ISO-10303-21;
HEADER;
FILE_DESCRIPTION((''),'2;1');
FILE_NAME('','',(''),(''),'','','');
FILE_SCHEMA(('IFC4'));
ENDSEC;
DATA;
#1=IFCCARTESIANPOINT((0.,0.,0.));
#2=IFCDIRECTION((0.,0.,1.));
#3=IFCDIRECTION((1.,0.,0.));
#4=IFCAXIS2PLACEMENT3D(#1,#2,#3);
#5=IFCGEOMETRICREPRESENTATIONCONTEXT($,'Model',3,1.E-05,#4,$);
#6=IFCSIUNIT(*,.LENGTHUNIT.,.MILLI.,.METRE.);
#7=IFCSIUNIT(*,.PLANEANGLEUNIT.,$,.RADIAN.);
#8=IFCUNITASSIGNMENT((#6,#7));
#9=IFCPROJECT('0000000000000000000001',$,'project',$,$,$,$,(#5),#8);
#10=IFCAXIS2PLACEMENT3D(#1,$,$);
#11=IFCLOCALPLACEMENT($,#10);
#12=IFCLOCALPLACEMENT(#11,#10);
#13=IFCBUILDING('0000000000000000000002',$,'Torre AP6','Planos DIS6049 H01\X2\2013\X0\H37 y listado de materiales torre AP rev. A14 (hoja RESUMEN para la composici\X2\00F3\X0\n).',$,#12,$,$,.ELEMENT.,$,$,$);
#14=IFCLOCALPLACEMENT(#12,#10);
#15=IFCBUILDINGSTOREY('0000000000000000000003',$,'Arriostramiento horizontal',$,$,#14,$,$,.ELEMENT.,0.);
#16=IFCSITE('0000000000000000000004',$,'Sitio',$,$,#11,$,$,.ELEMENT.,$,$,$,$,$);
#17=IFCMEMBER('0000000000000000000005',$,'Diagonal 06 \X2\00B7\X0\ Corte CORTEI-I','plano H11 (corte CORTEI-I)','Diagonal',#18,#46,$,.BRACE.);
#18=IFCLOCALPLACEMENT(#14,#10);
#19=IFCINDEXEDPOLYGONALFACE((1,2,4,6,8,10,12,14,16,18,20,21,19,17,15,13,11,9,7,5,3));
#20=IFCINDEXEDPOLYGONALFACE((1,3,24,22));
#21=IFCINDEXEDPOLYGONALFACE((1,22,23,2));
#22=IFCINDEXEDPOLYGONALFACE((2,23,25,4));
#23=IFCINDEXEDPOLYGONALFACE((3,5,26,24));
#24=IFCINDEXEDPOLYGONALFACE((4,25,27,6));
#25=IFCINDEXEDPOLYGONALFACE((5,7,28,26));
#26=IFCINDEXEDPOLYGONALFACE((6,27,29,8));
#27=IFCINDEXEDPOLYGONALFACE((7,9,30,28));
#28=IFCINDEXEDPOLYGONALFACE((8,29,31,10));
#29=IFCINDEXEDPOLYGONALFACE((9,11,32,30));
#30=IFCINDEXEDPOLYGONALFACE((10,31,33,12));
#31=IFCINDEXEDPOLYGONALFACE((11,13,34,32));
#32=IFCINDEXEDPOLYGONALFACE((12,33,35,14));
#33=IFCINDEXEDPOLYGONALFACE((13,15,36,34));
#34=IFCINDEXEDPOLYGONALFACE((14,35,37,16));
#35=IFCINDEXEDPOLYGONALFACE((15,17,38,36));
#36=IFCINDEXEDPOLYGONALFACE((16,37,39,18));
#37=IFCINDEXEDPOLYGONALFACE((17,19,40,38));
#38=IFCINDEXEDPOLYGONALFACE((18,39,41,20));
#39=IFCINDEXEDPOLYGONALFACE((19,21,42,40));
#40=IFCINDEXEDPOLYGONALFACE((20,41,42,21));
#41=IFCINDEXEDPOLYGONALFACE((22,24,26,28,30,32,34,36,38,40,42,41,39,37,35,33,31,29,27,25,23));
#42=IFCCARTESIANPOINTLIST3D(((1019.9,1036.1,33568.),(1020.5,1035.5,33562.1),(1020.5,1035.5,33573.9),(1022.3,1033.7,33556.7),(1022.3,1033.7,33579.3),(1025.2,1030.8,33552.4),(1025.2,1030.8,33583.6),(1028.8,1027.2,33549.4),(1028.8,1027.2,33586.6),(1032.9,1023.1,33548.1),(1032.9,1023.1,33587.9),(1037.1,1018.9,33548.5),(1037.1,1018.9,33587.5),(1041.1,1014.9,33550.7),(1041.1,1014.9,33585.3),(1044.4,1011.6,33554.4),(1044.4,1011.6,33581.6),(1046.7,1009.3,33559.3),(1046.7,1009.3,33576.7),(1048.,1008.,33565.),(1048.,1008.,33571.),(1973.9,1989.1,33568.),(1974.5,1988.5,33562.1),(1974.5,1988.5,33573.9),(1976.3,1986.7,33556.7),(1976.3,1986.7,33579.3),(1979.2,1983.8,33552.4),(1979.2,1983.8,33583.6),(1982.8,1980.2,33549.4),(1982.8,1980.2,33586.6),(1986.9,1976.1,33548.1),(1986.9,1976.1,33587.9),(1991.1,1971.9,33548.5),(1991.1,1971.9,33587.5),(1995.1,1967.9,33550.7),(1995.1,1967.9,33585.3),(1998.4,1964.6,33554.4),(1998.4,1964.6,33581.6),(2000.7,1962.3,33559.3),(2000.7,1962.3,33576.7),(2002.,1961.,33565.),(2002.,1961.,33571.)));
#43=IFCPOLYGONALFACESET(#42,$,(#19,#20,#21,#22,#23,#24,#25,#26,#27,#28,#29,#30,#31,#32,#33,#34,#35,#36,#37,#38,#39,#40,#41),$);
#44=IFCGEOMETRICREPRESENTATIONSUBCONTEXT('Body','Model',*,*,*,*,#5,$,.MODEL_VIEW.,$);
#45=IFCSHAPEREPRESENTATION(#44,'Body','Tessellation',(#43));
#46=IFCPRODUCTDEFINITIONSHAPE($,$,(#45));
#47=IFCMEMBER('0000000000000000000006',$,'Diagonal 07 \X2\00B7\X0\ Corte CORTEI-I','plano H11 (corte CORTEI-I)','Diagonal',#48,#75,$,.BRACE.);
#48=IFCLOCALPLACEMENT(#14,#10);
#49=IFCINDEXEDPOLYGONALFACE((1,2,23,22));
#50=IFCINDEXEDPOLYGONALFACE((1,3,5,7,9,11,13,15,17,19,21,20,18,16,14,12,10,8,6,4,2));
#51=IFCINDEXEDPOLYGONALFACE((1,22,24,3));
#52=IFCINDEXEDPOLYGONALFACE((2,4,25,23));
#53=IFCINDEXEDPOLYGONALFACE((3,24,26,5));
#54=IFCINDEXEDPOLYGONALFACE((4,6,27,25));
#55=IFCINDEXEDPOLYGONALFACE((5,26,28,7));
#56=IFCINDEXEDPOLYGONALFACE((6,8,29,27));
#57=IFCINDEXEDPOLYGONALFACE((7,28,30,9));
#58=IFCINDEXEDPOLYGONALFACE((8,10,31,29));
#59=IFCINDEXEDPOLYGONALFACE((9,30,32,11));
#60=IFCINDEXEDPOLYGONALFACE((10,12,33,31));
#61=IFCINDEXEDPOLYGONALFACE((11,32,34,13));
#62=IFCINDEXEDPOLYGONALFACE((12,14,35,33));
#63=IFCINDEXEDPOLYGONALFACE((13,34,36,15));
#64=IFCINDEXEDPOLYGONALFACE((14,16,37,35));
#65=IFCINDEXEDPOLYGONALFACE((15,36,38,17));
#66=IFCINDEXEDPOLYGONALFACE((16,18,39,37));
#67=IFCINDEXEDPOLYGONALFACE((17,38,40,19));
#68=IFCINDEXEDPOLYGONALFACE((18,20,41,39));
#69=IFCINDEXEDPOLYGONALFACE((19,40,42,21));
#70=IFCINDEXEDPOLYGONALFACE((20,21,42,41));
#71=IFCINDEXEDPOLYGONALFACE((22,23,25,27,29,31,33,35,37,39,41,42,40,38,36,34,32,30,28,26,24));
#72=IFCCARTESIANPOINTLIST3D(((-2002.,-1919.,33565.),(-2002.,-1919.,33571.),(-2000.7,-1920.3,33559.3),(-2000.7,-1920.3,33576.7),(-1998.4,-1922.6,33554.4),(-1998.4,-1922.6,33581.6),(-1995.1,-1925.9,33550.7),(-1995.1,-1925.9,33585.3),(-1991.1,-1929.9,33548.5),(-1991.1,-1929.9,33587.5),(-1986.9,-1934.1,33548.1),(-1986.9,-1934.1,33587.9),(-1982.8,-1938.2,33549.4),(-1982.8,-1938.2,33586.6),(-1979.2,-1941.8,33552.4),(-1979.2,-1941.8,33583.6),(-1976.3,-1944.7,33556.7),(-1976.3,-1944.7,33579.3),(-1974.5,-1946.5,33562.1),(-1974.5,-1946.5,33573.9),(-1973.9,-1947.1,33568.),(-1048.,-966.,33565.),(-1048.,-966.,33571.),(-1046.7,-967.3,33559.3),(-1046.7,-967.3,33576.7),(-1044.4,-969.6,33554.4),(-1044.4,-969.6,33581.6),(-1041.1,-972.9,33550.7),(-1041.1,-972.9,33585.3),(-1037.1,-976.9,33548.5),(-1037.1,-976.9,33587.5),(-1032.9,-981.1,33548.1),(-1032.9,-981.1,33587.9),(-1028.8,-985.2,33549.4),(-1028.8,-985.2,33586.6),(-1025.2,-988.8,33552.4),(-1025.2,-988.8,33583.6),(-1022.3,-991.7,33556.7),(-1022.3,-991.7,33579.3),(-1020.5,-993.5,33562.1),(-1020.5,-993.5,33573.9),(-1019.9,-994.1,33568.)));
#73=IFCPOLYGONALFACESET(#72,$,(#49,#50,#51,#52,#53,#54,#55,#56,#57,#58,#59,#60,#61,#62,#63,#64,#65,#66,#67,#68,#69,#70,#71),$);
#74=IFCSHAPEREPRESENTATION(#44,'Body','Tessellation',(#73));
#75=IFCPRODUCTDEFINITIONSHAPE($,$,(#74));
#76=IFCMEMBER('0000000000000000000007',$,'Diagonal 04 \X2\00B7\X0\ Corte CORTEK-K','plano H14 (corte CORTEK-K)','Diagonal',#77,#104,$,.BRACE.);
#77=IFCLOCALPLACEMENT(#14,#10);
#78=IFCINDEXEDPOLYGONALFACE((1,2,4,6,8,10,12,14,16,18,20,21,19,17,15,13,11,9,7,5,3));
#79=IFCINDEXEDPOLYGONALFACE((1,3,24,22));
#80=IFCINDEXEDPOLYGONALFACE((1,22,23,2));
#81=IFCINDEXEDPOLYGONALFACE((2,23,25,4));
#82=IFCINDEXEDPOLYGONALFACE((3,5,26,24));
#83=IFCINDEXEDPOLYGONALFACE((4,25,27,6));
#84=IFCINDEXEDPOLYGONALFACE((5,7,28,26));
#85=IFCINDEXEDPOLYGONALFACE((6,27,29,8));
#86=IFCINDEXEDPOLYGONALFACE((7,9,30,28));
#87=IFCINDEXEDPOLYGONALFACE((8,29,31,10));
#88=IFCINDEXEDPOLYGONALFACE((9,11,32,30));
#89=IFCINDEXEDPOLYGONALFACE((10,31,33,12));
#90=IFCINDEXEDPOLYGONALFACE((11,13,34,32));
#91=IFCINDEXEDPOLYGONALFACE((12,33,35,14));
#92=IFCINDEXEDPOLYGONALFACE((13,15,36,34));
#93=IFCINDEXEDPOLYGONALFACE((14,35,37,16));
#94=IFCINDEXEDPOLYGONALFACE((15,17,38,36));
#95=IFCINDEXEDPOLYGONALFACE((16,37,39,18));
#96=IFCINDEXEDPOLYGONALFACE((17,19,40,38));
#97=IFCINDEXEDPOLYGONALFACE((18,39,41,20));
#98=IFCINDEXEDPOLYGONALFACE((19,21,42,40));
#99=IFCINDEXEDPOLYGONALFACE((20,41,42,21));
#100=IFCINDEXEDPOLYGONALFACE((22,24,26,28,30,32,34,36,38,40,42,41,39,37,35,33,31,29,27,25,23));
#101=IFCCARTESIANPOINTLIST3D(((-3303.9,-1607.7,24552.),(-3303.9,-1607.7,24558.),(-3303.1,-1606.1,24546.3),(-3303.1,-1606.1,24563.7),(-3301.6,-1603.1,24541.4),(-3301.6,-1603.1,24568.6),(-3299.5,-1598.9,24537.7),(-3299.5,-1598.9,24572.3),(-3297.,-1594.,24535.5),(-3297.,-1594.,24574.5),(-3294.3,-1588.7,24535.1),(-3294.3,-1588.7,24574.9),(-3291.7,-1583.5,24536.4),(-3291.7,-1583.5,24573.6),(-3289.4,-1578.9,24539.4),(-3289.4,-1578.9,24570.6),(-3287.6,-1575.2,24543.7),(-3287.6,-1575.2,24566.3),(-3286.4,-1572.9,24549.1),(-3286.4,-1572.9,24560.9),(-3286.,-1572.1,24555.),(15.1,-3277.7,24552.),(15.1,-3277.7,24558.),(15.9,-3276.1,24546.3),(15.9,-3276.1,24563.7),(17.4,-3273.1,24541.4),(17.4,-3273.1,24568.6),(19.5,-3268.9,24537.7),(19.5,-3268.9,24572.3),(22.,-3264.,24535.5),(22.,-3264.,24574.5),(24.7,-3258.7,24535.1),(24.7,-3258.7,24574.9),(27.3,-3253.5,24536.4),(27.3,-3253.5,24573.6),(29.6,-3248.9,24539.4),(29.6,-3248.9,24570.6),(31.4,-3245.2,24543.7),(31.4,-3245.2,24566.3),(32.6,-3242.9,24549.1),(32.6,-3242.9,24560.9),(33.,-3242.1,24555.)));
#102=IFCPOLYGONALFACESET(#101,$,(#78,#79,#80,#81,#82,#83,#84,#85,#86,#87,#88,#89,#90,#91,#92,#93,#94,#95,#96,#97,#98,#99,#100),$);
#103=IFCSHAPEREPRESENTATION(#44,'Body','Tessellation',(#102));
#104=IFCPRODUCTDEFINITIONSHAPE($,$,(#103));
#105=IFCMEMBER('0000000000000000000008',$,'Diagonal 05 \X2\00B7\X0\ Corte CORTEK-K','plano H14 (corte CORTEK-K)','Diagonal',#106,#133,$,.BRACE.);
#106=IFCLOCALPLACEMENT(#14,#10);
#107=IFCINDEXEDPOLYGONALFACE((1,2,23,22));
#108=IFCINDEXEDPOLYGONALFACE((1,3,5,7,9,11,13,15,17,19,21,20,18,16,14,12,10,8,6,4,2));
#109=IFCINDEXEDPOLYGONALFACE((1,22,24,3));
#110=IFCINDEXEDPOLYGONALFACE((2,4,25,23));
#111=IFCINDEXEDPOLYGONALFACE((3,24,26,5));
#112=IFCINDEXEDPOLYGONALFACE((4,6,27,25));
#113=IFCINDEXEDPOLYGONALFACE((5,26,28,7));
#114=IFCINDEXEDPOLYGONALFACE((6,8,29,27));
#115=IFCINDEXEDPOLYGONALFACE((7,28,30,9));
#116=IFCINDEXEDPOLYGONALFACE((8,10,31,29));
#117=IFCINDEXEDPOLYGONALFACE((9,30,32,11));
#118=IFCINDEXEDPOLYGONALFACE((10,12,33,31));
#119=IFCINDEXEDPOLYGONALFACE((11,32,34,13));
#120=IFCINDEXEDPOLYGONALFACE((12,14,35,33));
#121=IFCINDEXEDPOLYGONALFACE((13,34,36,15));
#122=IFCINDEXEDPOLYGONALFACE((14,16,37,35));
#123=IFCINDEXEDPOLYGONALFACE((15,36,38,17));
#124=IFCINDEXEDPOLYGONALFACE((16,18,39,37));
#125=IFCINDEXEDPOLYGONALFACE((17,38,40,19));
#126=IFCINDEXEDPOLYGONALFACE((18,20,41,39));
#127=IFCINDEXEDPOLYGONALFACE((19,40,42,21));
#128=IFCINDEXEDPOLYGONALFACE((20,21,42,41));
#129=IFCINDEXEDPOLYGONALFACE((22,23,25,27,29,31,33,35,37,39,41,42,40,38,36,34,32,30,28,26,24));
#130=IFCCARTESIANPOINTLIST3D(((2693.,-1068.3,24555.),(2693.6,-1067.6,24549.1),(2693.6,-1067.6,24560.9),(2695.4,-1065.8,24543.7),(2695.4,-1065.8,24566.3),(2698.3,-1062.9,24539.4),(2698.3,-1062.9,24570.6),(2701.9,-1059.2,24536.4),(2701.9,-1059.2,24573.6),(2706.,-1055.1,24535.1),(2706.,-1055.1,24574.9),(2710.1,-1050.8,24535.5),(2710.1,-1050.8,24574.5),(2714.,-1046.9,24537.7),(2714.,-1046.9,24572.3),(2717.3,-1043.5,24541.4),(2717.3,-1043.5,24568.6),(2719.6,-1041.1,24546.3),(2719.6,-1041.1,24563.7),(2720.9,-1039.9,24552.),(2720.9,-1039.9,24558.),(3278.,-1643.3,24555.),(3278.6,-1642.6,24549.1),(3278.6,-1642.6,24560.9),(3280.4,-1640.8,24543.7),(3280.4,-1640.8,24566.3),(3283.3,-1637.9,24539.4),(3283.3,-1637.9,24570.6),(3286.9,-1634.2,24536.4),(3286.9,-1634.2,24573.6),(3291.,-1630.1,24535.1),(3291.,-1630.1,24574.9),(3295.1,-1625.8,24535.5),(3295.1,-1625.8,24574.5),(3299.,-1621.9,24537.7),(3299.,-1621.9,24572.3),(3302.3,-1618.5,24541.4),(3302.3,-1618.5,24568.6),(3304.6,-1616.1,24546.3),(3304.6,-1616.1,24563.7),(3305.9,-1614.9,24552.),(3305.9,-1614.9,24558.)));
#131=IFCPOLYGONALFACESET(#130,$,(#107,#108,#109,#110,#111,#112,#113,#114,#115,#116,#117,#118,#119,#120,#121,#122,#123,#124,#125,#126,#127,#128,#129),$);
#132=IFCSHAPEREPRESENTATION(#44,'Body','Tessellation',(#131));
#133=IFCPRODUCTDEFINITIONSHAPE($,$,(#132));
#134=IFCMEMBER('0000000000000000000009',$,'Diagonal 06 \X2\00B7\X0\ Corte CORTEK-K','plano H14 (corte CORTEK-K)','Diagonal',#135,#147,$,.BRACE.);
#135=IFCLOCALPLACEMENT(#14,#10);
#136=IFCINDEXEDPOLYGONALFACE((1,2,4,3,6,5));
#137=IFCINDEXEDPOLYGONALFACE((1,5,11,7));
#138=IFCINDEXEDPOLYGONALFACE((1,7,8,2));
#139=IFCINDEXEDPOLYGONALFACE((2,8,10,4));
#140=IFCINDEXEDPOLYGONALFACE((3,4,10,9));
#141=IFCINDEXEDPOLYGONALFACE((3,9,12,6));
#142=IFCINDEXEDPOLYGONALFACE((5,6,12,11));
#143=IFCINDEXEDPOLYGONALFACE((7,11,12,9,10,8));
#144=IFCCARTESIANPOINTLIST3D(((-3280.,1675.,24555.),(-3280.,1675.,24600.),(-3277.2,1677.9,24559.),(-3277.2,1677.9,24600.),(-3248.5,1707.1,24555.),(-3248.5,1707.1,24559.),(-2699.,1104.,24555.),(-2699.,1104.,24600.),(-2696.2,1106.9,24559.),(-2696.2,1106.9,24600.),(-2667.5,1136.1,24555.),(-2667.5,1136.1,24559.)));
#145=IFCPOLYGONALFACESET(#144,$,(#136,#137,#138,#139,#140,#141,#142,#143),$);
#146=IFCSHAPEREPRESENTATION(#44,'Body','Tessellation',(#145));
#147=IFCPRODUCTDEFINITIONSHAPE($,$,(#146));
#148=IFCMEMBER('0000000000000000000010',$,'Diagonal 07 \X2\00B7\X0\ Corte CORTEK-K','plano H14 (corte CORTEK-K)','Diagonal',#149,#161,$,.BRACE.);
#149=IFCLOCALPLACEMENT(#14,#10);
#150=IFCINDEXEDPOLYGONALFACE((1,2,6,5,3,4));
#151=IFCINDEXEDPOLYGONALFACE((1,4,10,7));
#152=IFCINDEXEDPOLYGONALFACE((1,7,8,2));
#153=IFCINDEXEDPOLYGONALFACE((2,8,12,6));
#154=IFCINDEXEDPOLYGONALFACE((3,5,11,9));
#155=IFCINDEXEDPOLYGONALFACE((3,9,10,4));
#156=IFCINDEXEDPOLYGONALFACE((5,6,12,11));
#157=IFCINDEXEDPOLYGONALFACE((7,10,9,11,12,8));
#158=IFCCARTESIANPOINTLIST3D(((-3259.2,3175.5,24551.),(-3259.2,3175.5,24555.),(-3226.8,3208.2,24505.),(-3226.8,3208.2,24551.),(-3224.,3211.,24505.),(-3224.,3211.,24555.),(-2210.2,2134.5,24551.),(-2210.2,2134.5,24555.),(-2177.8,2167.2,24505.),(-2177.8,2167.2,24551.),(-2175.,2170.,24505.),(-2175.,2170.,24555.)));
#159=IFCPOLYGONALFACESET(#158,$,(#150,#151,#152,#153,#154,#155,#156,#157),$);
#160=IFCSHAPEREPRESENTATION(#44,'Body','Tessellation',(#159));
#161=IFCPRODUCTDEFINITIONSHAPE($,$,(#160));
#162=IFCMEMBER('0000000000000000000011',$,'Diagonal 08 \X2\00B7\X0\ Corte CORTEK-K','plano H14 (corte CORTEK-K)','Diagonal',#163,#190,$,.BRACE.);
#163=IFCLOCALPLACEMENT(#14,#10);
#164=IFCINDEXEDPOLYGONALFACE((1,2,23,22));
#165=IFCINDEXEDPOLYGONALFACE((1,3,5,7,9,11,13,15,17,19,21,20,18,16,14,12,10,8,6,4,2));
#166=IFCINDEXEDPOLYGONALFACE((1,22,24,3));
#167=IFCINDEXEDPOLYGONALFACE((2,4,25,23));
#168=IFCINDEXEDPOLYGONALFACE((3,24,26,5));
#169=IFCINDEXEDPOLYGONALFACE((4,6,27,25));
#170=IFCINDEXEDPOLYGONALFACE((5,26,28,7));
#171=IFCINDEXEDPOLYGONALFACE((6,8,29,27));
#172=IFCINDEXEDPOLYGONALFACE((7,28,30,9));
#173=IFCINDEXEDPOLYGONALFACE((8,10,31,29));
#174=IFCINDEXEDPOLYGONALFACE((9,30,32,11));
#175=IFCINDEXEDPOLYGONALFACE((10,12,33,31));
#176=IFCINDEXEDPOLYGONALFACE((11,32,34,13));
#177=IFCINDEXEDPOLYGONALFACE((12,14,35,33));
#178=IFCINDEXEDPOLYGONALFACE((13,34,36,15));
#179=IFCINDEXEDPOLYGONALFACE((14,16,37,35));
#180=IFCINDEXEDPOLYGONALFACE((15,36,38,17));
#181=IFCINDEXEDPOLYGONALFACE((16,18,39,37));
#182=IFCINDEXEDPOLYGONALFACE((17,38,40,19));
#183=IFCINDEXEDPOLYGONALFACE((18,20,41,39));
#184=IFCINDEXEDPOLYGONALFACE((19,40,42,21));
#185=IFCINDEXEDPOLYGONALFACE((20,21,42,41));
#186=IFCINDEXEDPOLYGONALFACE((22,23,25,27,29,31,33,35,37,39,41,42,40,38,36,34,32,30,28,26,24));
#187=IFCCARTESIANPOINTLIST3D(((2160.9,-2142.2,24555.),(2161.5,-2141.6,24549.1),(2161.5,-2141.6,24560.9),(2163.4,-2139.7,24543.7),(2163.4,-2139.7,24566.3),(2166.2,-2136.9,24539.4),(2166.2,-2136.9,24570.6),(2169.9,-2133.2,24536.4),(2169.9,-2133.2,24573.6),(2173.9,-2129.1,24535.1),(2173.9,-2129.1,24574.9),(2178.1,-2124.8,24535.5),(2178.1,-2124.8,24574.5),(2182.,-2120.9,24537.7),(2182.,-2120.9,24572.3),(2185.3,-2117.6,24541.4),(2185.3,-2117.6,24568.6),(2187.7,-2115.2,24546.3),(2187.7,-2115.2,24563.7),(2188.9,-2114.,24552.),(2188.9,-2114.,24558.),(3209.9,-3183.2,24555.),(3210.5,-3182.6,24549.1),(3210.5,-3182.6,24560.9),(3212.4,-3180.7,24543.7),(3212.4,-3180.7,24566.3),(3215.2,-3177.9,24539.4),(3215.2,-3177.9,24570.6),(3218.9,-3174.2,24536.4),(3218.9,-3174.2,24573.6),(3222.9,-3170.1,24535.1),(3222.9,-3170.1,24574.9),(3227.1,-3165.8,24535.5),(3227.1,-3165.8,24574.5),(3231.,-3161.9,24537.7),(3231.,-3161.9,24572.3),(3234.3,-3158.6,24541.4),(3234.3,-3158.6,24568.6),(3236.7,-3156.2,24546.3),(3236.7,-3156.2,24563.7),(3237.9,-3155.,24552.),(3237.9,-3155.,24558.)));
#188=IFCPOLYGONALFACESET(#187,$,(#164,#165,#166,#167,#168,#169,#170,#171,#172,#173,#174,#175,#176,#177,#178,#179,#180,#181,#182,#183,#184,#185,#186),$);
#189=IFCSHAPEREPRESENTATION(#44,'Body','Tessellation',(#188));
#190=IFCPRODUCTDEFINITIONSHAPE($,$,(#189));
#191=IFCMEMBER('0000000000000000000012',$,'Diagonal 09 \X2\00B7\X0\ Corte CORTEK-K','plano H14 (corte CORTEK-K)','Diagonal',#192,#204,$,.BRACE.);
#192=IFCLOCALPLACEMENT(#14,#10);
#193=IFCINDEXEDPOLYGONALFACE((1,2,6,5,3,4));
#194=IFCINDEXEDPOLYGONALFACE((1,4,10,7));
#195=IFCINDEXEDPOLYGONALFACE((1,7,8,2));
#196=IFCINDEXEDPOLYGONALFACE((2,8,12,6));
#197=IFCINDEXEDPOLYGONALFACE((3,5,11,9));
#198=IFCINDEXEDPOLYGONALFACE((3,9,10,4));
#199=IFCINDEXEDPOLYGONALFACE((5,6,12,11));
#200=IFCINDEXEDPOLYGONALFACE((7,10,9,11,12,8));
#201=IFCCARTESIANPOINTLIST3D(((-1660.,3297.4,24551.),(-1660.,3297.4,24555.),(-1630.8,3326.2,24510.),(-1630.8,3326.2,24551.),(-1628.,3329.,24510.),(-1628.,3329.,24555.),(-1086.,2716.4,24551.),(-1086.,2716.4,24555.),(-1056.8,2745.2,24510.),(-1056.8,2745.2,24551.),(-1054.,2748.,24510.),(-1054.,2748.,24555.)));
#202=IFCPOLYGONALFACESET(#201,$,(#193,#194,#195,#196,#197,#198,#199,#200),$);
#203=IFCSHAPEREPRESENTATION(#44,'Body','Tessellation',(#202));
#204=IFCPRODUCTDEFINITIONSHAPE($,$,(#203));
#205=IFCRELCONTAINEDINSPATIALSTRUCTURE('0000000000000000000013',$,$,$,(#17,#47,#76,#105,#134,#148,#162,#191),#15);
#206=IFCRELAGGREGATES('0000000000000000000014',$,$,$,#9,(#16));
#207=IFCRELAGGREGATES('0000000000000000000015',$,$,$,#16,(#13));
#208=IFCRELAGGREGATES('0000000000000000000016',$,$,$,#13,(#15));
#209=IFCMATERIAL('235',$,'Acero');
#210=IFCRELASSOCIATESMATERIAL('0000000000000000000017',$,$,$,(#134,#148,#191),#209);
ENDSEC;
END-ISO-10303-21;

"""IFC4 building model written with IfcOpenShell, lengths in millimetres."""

from ifc_helpers import new_model, si_unit, frame, frame_2d, origin, origin_with_axes, place, context, subcontext, project, spatial, circle, l_section, extrude, material, element, save


model = new_model("IFC4")

# Units and contexts
model_context = context("Model", 3, precision=1e-05, world=origin_with_axes())
body_context = subcontext(model_context, "Body", "Model", "MODEL_VIEW")
ifc_project = project(units=[si_unit("LENGTHUNIT", "METRE", prefix="MILLI"), si_unit("PLANEANGLEUNIT", "RADIAN")], contexts=[model_context])

# Site, building, storey
site_placement = place(None, origin())
site = spatial("IfcSite", under=ifc_project, at=site_placement, Name="Sitio", CompositionType="ELEMENT")
building_placement = place(site_placement, origin())
building = spatial("IfcBuilding", under=site, at=building_placement, Name="Torre AP6", Description="Planos DIS6049 H01–H37 y listado de materiales torre AP rev. A14 (hoja RESUMEN para la composición).", CompositionType="ELEMENT")
storey_placement = place(building_placement, origin())
storey = spatial("IfcBuildingStorey", under=building, at=storey_placement, Name="Arriostramiento horizontal", CompositionType="ELEMENT", Elevation=0.0)

# Members
ifc_material = material(Name="235", Category="Acero")
for number, where, z_axis, x_axis, name in (
    (1, (1988.0, 1975.0, 33568.0), (-0.707477, -0.706736, 0.0), (-0.706736, 0.707477, 0.0), "Diagonal 06 · Corte CORTEI-I"),
    (2, (-1034.0, -980.0, 33568.0), (-0.707477, -0.706736, 0.0), (0.706736, -0.707477, 0.0), "Diagonal 07 · Corte CORTEI-I"),
):
    element("IfcMember", number, at=place(storey_placement, frame(where, z_axis=z_axis, x_axis=x_axis)), inside=storey, Name=name, Description="plano H11 (corte CORTEI-I)", ObjectType="Diagonal", PredefinedType="BRACE", context=body_context, shape_type="SweptSolid", body=[
        extrude(circle(Radius=20.0), None, (0.0, 0.0, 1.0), 1348.5),
    ])
member_1_placement = place(storey_placement, frame((-3295.0, -1590.0, 24555.0), z_axis=(0.893294, -0.449473, 0.0), x_axis=(0.449473, 0.893294, 0.0)))
element("IfcMember", 3, at=member_1_placement, inside=storey, Name="Diagonal 04 · Corte CORTEK-K", Description="plano H14 (corte CORTEK-K)", ObjectType="Diagonal", PredefinedType="BRACE", context=body_context, shape_type="SweptSolid", body=[
    extrude(circle(Radius=20.0), None, (0.0, 0.0, 1.0), 3715.5),
])
member_2_placement = place(storey_placement, frame((2707.0, -1054.0, 24555.0), z_axis=(0.713176, -0.700985, 0.0), x_axis=(-0.700985, -0.713176, 0.0)))
element("IfcMember", 4, at=member_2_placement, inside=storey, Name="Diagonal 05 · Corte CORTEK-K", Description="plano H14 (corte CORTEK-K)", ObjectType="Diagonal", PredefinedType="BRACE", context=body_context, shape_type="SweptSolid", body=[
    extrude(circle(Radius=20.0), None, (0.0, 0.0, 1.0), 820.3),
])
member_3_placement = place(storey_placement, frame((-3280.0, 1675.0, 24555.0), z_axis=(0.713218, -0.700942, 0.0), x_axis=(0.700942, 0.713218, 0.0)))
element("IfcMember", 5, at=member_3_placement, inside=storey, material=ifc_material, Name="Diagonal 06 · Corte CORTEK-K", Description="plano H14 (corte CORTEK-K)", ObjectType="Diagonal", PredefinedType="BRACE", context=body_context, shape_type="SweptSolid", body=[
    extrude(l_section(Depth=45.0, Width=45.0, Thickness=4.0, at=frame_2d((22.5, 22.5))), None, (0.0, 0.0, 1.0), 814.6),
])
member_4_placement = place(storey_placement, frame((-3224.0, 3211.0, 24555.0), z_axis=(0.709808, -0.704395, 0.0), x_axis=(-0.704395, -0.709808, 0.0)))
element("IfcMember", 6, at=member_4_placement, inside=storey, material=ifc_material, Name="Diagonal 07 · Corte CORTEK-K", Description="plano H14 (corte CORTEK-K)", ObjectType="Diagonal", PredefinedType="BRACE", context=body_context, shape_type="SweptSolid", body=[
    extrude(l_section(Depth=50.0, Width=50.0, Thickness=4.0, at=frame_2d((25.0, 25.0))), None, (0.0, 0.0, 1.0), 1477.9),
])
member_5_placement = place(storey_placement, frame((2175.0, -2128.0, 24555.0), z_axis=(0.709808, -0.704395, 0.0), x_axis=(-0.704395, -0.709808, 0.0)))
element("IfcMember", 7, at=member_5_placement, inside=storey, Name="Diagonal 08 · Corte CORTEK-K", Description="plano H14 (corte CORTEK-K)", ObjectType="Diagonal", PredefinedType="BRACE", context=body_context, shape_type="SweptSolid", body=[
    extrude(circle(Radius=20.0), None, (0.0, 0.0, 1.0), 1477.9),
])
member_6_placement = place(storey_placement, frame((-1628.0, 3329.0, 24555.0), z_axis=(0.702808, -0.711379, 0.0), x_axis=(-0.711379, -0.702808, 0.0)))
element("IfcMember", 8, at=member_6_placement, inside=storey, material=ifc_material, Name="Diagonal 09 · Corte CORTEK-K", Description="plano H14 (corte CORTEK-K)", ObjectType="Diagonal", PredefinedType="BRACE", context=body_context, shape_type="SweptSolid", body=[
    extrude(l_section(Depth=45.0, Width=45.0, Thickness=4.0, at=frame_2d((22.5, 22.5))), None, (0.0, 0.0, 1.0), 816.7),
])

save(model, "model.ifc")
